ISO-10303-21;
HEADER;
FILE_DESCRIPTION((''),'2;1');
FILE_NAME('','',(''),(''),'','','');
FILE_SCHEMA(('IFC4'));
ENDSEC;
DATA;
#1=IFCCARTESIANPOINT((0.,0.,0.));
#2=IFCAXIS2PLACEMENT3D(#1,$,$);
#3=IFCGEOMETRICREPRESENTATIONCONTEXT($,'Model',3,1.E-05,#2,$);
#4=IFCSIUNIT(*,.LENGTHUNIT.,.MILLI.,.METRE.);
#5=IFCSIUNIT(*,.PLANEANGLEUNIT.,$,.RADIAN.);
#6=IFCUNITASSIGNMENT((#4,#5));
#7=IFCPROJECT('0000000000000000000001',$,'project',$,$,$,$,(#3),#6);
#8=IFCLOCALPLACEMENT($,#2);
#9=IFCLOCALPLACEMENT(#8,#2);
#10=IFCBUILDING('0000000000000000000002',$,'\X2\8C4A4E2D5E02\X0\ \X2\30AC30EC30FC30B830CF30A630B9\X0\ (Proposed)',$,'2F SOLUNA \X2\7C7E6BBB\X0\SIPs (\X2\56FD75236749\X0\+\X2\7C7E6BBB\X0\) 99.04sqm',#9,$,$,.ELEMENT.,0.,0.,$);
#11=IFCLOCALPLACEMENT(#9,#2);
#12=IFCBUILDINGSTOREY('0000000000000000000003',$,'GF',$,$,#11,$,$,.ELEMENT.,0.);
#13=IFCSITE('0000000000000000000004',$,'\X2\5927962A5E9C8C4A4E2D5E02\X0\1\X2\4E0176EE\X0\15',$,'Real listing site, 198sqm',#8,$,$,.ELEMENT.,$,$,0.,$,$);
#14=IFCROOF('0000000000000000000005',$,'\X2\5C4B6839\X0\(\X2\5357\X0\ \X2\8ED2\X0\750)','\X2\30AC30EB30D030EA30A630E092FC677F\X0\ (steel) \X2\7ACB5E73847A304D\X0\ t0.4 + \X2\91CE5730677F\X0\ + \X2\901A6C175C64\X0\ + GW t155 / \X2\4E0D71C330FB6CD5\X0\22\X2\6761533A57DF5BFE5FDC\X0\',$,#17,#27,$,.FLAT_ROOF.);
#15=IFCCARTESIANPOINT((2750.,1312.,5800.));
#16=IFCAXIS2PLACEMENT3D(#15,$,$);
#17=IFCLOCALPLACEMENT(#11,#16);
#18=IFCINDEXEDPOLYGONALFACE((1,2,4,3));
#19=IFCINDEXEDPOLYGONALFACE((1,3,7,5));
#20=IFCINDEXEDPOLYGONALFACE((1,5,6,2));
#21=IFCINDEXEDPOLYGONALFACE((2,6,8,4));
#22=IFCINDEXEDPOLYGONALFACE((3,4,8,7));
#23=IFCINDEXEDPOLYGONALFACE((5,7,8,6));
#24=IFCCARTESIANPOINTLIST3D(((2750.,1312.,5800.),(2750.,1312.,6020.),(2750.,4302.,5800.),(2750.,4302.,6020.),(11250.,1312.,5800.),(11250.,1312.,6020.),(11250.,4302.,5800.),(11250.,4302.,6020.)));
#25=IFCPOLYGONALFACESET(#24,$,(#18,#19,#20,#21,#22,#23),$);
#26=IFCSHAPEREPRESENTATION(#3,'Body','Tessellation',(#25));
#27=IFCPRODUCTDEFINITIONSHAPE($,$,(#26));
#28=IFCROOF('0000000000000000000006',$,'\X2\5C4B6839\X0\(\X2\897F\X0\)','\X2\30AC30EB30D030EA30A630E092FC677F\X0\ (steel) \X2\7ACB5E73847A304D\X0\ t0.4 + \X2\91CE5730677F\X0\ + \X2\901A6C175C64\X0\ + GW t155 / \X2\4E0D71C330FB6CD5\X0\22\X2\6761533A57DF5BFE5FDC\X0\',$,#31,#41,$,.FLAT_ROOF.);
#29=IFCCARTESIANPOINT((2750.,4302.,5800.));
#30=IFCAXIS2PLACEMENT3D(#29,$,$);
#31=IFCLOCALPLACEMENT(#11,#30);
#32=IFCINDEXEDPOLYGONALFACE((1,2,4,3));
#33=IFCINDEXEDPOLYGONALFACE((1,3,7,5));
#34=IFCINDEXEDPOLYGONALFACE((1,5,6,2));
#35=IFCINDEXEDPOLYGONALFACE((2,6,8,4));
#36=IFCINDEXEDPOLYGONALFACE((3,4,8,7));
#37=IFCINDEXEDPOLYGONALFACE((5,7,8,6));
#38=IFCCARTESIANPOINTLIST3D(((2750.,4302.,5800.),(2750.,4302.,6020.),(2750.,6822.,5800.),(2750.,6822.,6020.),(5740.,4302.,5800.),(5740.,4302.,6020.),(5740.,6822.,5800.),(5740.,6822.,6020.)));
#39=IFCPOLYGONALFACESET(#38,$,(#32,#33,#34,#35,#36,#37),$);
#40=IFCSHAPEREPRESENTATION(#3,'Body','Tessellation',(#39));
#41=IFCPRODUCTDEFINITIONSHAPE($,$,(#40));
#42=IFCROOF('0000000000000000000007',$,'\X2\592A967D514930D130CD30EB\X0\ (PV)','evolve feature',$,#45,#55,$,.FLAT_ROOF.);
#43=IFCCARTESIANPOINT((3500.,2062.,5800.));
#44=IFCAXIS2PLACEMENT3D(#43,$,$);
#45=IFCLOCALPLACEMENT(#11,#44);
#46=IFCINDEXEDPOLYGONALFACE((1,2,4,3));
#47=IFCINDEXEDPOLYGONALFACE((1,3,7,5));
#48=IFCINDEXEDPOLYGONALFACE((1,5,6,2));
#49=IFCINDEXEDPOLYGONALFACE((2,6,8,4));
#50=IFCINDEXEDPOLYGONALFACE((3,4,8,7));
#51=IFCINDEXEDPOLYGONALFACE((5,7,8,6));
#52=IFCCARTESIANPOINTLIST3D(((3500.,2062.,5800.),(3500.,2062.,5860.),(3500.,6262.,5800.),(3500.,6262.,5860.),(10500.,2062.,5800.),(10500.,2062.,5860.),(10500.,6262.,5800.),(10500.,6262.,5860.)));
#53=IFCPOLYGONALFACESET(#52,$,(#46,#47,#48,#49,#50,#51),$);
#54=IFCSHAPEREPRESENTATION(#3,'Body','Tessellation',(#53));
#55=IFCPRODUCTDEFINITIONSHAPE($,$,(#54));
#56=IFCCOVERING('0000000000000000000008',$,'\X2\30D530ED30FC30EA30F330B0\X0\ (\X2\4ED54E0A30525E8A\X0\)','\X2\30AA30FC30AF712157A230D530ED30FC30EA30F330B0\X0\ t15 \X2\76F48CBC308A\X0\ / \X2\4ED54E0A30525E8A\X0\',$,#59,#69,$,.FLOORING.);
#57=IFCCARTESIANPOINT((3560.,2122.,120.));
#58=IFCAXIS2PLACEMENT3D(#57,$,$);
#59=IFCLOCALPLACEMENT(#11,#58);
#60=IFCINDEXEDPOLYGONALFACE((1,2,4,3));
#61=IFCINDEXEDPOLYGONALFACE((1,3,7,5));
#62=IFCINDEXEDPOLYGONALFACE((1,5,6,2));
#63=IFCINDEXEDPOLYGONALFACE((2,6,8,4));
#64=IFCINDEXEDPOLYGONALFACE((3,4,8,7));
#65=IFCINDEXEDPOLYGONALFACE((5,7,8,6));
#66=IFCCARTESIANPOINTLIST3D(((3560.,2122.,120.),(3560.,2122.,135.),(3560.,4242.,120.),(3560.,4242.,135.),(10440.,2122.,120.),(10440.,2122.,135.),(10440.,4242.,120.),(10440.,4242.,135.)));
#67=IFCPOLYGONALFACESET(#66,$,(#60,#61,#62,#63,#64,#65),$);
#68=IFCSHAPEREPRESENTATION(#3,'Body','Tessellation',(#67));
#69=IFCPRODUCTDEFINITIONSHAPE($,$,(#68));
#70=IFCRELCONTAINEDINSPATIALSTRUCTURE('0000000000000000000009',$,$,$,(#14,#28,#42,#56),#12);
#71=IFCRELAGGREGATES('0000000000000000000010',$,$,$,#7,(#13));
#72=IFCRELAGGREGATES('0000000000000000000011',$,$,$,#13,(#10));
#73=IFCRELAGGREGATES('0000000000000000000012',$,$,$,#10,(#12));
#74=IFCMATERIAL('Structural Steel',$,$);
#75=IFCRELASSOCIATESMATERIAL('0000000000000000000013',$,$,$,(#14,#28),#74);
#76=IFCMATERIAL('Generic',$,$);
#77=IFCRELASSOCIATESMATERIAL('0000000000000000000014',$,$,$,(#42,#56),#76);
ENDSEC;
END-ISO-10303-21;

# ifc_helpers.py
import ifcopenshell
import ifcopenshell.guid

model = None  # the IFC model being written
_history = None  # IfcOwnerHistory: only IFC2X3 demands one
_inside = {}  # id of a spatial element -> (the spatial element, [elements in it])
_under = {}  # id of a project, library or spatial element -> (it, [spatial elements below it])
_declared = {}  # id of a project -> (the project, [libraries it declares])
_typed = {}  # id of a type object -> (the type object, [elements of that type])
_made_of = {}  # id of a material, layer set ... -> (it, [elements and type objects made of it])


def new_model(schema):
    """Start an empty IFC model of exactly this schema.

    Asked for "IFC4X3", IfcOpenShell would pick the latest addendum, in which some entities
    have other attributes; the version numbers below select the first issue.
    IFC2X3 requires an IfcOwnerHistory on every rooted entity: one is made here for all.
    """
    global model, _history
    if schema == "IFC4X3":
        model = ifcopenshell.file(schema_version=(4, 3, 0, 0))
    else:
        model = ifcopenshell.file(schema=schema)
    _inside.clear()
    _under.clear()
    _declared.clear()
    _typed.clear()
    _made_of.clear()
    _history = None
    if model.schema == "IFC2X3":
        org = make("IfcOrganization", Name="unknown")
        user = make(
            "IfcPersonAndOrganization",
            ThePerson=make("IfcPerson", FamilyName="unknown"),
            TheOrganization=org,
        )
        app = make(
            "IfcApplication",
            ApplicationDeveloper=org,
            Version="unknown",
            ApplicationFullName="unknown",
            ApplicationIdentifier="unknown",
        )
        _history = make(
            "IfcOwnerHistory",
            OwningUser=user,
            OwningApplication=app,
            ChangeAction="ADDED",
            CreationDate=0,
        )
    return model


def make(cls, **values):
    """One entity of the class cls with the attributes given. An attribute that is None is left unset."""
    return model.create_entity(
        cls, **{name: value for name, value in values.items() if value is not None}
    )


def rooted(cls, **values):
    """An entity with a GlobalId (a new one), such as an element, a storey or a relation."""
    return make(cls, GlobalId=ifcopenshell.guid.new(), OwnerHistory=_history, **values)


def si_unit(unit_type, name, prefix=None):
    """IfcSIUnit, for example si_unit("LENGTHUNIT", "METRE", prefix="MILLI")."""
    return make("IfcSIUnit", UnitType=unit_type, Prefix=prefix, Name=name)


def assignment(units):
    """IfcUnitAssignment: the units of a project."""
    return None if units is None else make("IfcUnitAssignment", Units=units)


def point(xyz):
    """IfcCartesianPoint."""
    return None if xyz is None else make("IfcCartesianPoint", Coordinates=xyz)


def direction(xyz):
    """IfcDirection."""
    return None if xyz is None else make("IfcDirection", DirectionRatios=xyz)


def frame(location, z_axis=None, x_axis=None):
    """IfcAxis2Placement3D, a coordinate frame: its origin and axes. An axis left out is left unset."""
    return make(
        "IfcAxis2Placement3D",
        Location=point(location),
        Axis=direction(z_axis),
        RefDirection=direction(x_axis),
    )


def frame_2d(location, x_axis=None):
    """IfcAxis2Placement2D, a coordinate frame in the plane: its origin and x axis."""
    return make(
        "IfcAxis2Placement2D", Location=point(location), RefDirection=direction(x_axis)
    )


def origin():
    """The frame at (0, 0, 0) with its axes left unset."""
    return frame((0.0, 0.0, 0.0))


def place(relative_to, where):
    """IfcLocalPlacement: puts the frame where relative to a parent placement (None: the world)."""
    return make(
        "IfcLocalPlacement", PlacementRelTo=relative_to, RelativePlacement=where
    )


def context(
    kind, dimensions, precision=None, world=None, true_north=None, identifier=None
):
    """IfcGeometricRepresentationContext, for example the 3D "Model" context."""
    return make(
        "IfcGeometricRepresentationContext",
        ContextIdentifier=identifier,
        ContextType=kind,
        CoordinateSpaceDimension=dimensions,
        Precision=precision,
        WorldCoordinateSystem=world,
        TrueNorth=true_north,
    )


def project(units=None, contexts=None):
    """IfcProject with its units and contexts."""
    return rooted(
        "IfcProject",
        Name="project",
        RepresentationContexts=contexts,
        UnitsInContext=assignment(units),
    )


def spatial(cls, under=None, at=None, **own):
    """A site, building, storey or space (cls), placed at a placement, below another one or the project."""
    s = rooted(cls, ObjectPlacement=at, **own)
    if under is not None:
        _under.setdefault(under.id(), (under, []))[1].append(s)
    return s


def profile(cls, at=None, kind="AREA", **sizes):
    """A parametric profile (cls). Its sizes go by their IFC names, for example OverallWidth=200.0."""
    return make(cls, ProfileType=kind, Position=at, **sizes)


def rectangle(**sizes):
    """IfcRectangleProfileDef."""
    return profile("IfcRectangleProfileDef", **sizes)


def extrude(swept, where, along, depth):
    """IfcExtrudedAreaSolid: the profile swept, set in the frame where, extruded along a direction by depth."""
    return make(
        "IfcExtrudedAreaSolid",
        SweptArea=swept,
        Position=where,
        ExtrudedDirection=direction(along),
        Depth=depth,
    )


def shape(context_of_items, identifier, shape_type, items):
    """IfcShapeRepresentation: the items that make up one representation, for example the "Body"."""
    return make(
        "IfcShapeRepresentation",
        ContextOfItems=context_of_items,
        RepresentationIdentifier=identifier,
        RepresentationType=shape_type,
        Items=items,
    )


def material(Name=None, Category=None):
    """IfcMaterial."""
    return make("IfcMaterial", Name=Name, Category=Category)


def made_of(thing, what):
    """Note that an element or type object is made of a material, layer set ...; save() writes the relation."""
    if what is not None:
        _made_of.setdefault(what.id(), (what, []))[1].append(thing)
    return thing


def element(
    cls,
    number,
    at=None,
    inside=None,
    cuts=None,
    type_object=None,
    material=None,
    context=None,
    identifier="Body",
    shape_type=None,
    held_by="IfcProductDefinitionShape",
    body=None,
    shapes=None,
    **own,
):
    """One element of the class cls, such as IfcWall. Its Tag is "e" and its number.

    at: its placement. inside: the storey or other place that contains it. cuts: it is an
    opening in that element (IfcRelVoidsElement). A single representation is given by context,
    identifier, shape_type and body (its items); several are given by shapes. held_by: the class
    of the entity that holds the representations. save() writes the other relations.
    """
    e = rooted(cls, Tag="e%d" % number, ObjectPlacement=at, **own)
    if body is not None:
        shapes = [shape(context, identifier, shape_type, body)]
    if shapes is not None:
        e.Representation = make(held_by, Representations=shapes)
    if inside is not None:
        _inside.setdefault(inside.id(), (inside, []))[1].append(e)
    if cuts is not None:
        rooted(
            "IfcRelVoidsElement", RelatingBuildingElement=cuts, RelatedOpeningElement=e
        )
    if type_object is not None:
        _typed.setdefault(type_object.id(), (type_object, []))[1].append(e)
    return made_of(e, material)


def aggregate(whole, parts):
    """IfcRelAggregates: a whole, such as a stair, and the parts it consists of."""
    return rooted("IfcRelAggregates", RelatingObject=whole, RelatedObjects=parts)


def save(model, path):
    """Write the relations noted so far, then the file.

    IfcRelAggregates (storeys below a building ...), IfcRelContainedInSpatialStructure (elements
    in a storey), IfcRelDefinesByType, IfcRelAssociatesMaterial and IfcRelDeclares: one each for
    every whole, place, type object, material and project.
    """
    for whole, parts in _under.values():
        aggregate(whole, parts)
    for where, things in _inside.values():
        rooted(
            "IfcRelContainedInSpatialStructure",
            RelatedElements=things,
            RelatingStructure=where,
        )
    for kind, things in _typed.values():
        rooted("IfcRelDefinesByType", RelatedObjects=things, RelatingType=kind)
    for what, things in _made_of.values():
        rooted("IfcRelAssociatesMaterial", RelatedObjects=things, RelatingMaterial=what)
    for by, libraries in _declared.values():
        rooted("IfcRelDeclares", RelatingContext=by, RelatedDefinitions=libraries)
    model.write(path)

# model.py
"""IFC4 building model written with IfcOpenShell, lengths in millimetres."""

from ifc_helpers import new_model, si_unit, frame, frame_2d, origin, place, context, project, spatial, rectangle, extrude, material, element, save


model = new_model("IFC4")

# Units and contexts
model_context = context("Model", 3, precision=1e-05, world=origin())
ifc_project = project(units=[si_unit("LENGTHUNIT", "METRE", prefix="MILLI"), si_unit("PLANEANGLEUNIT", "RADIAN")], contexts=[model_context])

# Site, building, storey
site_placement = place(None, origin())
site = spatial("IfcSite", under=ifc_project, at=site_placement, Name="大阪府豊中市1丁目15", ObjectType="Real listing site, 198sqm", CompositionType="ELEMENT", RefElevation=0.0)
building_placement = place(site_placement, origin())
building = spatial("IfcBuilding", under=site, at=building_placement, Name="豊中市 ガレージハウス (Proposed)", ObjectType="2F SOLUNA 籾殻SIPs (国産杉+籾殻) 99.04sqm", CompositionType="ELEMENT", ElevationOfRefHeight=0.0, ElevationOfTerrain=0.0)
storey_placement = place(building_placement, origin())
storey = spatial("IfcBuildingStorey", under=building, at=storey_placement, Name="GF", CompositionType="ELEMENT", Elevation=0.0)

# Shared definitions
ifc_material_1 = material(Name="Generic")

# Roofs
ifc_material_2 = material(Name="Structural Steel")
roof_1_placement = place(storey_placement, frame((2750.0, 1312.0, 5800.0)))
element("IfcRoof", 1, at=roof_1_placement, inside=storey, material=ifc_material_2, Name="屋根(南 軒750)", Description="ガルバリウム鋼板 (steel) 立平葺き t0.4 + 野地板 + 通気層 + GW t155 / 不燃・法22条区域対応", PredefinedType="FLAT_ROOF", context=model_context, shape_type="SweptSolid", body=[
    extrude(rectangle(XDim=8500.0, YDim=2990.0, at=frame_2d((4250.0, 1495.0))), frame((2750.0, 1312.0, 5800.0)), (0.0, 0.0, 1.0), 220.0),
])
roof_2_placement = place(storey_placement, frame((2750.0, 4302.0, 5800.0)))
element("IfcRoof", 2, at=roof_2_placement, inside=storey, material=ifc_material_2, Name="屋根(西)", Description="ガルバリウム鋼板 (steel) 立平葺き t0.4 + 野地板 + 通気層 + GW t155 / 不燃・法22条区域対応", PredefinedType="FLAT_ROOF", context=model_context, shape_type="SweptSolid", body=[
    extrude(rectangle(XDim=2990.0, YDim=2520.0, at=frame_2d((1495.0, 1260.0))), frame((2750.0, 4302.0, 5800.0)), (0.0, 0.0, 1.0), 220.0),
])
roof_3_placement = place(storey_placement, frame((3500.0, 2062.0, 5800.0)))
element("IfcRoof", 3, at=roof_3_placement, inside=storey, material=ifc_material_1, Name="太陽光パネル (PV)", Description="evolve feature", PredefinedType="FLAT_ROOF", context=model_context, shape_type="SweptSolid", body=[
    extrude(rectangle(XDim=7000.0, YDim=4200.0, at=frame_2d((3500.0, 2100.0))), frame((3500.0, 2062.0, 5800.0)), (0.0, 0.0, 1.0), 60.0),
])

# Covering
covering_placement = place(storey_placement, frame((3560.0, 2122.0, 120.0)))
element("IfcCovering", 4, at=covering_placement, inside=storey, material=ifc_material_1, Name="フローリング (仕上げ床)", Description="オーク無垢フローリング t15 直貼り / 仕上げ床", PredefinedType="FLOORING", context=model_context, shape_type="SweptSolid", body=[
    extrude(rectangle(XDim=6880.0, YDim=2120.0, at=frame_2d((3440.0, 1060.0))), frame((3560.0, 2122.0, 120.0)), (0.0, 0.0, 1.0), 15.0),
])

save(model, "model.ifc")
